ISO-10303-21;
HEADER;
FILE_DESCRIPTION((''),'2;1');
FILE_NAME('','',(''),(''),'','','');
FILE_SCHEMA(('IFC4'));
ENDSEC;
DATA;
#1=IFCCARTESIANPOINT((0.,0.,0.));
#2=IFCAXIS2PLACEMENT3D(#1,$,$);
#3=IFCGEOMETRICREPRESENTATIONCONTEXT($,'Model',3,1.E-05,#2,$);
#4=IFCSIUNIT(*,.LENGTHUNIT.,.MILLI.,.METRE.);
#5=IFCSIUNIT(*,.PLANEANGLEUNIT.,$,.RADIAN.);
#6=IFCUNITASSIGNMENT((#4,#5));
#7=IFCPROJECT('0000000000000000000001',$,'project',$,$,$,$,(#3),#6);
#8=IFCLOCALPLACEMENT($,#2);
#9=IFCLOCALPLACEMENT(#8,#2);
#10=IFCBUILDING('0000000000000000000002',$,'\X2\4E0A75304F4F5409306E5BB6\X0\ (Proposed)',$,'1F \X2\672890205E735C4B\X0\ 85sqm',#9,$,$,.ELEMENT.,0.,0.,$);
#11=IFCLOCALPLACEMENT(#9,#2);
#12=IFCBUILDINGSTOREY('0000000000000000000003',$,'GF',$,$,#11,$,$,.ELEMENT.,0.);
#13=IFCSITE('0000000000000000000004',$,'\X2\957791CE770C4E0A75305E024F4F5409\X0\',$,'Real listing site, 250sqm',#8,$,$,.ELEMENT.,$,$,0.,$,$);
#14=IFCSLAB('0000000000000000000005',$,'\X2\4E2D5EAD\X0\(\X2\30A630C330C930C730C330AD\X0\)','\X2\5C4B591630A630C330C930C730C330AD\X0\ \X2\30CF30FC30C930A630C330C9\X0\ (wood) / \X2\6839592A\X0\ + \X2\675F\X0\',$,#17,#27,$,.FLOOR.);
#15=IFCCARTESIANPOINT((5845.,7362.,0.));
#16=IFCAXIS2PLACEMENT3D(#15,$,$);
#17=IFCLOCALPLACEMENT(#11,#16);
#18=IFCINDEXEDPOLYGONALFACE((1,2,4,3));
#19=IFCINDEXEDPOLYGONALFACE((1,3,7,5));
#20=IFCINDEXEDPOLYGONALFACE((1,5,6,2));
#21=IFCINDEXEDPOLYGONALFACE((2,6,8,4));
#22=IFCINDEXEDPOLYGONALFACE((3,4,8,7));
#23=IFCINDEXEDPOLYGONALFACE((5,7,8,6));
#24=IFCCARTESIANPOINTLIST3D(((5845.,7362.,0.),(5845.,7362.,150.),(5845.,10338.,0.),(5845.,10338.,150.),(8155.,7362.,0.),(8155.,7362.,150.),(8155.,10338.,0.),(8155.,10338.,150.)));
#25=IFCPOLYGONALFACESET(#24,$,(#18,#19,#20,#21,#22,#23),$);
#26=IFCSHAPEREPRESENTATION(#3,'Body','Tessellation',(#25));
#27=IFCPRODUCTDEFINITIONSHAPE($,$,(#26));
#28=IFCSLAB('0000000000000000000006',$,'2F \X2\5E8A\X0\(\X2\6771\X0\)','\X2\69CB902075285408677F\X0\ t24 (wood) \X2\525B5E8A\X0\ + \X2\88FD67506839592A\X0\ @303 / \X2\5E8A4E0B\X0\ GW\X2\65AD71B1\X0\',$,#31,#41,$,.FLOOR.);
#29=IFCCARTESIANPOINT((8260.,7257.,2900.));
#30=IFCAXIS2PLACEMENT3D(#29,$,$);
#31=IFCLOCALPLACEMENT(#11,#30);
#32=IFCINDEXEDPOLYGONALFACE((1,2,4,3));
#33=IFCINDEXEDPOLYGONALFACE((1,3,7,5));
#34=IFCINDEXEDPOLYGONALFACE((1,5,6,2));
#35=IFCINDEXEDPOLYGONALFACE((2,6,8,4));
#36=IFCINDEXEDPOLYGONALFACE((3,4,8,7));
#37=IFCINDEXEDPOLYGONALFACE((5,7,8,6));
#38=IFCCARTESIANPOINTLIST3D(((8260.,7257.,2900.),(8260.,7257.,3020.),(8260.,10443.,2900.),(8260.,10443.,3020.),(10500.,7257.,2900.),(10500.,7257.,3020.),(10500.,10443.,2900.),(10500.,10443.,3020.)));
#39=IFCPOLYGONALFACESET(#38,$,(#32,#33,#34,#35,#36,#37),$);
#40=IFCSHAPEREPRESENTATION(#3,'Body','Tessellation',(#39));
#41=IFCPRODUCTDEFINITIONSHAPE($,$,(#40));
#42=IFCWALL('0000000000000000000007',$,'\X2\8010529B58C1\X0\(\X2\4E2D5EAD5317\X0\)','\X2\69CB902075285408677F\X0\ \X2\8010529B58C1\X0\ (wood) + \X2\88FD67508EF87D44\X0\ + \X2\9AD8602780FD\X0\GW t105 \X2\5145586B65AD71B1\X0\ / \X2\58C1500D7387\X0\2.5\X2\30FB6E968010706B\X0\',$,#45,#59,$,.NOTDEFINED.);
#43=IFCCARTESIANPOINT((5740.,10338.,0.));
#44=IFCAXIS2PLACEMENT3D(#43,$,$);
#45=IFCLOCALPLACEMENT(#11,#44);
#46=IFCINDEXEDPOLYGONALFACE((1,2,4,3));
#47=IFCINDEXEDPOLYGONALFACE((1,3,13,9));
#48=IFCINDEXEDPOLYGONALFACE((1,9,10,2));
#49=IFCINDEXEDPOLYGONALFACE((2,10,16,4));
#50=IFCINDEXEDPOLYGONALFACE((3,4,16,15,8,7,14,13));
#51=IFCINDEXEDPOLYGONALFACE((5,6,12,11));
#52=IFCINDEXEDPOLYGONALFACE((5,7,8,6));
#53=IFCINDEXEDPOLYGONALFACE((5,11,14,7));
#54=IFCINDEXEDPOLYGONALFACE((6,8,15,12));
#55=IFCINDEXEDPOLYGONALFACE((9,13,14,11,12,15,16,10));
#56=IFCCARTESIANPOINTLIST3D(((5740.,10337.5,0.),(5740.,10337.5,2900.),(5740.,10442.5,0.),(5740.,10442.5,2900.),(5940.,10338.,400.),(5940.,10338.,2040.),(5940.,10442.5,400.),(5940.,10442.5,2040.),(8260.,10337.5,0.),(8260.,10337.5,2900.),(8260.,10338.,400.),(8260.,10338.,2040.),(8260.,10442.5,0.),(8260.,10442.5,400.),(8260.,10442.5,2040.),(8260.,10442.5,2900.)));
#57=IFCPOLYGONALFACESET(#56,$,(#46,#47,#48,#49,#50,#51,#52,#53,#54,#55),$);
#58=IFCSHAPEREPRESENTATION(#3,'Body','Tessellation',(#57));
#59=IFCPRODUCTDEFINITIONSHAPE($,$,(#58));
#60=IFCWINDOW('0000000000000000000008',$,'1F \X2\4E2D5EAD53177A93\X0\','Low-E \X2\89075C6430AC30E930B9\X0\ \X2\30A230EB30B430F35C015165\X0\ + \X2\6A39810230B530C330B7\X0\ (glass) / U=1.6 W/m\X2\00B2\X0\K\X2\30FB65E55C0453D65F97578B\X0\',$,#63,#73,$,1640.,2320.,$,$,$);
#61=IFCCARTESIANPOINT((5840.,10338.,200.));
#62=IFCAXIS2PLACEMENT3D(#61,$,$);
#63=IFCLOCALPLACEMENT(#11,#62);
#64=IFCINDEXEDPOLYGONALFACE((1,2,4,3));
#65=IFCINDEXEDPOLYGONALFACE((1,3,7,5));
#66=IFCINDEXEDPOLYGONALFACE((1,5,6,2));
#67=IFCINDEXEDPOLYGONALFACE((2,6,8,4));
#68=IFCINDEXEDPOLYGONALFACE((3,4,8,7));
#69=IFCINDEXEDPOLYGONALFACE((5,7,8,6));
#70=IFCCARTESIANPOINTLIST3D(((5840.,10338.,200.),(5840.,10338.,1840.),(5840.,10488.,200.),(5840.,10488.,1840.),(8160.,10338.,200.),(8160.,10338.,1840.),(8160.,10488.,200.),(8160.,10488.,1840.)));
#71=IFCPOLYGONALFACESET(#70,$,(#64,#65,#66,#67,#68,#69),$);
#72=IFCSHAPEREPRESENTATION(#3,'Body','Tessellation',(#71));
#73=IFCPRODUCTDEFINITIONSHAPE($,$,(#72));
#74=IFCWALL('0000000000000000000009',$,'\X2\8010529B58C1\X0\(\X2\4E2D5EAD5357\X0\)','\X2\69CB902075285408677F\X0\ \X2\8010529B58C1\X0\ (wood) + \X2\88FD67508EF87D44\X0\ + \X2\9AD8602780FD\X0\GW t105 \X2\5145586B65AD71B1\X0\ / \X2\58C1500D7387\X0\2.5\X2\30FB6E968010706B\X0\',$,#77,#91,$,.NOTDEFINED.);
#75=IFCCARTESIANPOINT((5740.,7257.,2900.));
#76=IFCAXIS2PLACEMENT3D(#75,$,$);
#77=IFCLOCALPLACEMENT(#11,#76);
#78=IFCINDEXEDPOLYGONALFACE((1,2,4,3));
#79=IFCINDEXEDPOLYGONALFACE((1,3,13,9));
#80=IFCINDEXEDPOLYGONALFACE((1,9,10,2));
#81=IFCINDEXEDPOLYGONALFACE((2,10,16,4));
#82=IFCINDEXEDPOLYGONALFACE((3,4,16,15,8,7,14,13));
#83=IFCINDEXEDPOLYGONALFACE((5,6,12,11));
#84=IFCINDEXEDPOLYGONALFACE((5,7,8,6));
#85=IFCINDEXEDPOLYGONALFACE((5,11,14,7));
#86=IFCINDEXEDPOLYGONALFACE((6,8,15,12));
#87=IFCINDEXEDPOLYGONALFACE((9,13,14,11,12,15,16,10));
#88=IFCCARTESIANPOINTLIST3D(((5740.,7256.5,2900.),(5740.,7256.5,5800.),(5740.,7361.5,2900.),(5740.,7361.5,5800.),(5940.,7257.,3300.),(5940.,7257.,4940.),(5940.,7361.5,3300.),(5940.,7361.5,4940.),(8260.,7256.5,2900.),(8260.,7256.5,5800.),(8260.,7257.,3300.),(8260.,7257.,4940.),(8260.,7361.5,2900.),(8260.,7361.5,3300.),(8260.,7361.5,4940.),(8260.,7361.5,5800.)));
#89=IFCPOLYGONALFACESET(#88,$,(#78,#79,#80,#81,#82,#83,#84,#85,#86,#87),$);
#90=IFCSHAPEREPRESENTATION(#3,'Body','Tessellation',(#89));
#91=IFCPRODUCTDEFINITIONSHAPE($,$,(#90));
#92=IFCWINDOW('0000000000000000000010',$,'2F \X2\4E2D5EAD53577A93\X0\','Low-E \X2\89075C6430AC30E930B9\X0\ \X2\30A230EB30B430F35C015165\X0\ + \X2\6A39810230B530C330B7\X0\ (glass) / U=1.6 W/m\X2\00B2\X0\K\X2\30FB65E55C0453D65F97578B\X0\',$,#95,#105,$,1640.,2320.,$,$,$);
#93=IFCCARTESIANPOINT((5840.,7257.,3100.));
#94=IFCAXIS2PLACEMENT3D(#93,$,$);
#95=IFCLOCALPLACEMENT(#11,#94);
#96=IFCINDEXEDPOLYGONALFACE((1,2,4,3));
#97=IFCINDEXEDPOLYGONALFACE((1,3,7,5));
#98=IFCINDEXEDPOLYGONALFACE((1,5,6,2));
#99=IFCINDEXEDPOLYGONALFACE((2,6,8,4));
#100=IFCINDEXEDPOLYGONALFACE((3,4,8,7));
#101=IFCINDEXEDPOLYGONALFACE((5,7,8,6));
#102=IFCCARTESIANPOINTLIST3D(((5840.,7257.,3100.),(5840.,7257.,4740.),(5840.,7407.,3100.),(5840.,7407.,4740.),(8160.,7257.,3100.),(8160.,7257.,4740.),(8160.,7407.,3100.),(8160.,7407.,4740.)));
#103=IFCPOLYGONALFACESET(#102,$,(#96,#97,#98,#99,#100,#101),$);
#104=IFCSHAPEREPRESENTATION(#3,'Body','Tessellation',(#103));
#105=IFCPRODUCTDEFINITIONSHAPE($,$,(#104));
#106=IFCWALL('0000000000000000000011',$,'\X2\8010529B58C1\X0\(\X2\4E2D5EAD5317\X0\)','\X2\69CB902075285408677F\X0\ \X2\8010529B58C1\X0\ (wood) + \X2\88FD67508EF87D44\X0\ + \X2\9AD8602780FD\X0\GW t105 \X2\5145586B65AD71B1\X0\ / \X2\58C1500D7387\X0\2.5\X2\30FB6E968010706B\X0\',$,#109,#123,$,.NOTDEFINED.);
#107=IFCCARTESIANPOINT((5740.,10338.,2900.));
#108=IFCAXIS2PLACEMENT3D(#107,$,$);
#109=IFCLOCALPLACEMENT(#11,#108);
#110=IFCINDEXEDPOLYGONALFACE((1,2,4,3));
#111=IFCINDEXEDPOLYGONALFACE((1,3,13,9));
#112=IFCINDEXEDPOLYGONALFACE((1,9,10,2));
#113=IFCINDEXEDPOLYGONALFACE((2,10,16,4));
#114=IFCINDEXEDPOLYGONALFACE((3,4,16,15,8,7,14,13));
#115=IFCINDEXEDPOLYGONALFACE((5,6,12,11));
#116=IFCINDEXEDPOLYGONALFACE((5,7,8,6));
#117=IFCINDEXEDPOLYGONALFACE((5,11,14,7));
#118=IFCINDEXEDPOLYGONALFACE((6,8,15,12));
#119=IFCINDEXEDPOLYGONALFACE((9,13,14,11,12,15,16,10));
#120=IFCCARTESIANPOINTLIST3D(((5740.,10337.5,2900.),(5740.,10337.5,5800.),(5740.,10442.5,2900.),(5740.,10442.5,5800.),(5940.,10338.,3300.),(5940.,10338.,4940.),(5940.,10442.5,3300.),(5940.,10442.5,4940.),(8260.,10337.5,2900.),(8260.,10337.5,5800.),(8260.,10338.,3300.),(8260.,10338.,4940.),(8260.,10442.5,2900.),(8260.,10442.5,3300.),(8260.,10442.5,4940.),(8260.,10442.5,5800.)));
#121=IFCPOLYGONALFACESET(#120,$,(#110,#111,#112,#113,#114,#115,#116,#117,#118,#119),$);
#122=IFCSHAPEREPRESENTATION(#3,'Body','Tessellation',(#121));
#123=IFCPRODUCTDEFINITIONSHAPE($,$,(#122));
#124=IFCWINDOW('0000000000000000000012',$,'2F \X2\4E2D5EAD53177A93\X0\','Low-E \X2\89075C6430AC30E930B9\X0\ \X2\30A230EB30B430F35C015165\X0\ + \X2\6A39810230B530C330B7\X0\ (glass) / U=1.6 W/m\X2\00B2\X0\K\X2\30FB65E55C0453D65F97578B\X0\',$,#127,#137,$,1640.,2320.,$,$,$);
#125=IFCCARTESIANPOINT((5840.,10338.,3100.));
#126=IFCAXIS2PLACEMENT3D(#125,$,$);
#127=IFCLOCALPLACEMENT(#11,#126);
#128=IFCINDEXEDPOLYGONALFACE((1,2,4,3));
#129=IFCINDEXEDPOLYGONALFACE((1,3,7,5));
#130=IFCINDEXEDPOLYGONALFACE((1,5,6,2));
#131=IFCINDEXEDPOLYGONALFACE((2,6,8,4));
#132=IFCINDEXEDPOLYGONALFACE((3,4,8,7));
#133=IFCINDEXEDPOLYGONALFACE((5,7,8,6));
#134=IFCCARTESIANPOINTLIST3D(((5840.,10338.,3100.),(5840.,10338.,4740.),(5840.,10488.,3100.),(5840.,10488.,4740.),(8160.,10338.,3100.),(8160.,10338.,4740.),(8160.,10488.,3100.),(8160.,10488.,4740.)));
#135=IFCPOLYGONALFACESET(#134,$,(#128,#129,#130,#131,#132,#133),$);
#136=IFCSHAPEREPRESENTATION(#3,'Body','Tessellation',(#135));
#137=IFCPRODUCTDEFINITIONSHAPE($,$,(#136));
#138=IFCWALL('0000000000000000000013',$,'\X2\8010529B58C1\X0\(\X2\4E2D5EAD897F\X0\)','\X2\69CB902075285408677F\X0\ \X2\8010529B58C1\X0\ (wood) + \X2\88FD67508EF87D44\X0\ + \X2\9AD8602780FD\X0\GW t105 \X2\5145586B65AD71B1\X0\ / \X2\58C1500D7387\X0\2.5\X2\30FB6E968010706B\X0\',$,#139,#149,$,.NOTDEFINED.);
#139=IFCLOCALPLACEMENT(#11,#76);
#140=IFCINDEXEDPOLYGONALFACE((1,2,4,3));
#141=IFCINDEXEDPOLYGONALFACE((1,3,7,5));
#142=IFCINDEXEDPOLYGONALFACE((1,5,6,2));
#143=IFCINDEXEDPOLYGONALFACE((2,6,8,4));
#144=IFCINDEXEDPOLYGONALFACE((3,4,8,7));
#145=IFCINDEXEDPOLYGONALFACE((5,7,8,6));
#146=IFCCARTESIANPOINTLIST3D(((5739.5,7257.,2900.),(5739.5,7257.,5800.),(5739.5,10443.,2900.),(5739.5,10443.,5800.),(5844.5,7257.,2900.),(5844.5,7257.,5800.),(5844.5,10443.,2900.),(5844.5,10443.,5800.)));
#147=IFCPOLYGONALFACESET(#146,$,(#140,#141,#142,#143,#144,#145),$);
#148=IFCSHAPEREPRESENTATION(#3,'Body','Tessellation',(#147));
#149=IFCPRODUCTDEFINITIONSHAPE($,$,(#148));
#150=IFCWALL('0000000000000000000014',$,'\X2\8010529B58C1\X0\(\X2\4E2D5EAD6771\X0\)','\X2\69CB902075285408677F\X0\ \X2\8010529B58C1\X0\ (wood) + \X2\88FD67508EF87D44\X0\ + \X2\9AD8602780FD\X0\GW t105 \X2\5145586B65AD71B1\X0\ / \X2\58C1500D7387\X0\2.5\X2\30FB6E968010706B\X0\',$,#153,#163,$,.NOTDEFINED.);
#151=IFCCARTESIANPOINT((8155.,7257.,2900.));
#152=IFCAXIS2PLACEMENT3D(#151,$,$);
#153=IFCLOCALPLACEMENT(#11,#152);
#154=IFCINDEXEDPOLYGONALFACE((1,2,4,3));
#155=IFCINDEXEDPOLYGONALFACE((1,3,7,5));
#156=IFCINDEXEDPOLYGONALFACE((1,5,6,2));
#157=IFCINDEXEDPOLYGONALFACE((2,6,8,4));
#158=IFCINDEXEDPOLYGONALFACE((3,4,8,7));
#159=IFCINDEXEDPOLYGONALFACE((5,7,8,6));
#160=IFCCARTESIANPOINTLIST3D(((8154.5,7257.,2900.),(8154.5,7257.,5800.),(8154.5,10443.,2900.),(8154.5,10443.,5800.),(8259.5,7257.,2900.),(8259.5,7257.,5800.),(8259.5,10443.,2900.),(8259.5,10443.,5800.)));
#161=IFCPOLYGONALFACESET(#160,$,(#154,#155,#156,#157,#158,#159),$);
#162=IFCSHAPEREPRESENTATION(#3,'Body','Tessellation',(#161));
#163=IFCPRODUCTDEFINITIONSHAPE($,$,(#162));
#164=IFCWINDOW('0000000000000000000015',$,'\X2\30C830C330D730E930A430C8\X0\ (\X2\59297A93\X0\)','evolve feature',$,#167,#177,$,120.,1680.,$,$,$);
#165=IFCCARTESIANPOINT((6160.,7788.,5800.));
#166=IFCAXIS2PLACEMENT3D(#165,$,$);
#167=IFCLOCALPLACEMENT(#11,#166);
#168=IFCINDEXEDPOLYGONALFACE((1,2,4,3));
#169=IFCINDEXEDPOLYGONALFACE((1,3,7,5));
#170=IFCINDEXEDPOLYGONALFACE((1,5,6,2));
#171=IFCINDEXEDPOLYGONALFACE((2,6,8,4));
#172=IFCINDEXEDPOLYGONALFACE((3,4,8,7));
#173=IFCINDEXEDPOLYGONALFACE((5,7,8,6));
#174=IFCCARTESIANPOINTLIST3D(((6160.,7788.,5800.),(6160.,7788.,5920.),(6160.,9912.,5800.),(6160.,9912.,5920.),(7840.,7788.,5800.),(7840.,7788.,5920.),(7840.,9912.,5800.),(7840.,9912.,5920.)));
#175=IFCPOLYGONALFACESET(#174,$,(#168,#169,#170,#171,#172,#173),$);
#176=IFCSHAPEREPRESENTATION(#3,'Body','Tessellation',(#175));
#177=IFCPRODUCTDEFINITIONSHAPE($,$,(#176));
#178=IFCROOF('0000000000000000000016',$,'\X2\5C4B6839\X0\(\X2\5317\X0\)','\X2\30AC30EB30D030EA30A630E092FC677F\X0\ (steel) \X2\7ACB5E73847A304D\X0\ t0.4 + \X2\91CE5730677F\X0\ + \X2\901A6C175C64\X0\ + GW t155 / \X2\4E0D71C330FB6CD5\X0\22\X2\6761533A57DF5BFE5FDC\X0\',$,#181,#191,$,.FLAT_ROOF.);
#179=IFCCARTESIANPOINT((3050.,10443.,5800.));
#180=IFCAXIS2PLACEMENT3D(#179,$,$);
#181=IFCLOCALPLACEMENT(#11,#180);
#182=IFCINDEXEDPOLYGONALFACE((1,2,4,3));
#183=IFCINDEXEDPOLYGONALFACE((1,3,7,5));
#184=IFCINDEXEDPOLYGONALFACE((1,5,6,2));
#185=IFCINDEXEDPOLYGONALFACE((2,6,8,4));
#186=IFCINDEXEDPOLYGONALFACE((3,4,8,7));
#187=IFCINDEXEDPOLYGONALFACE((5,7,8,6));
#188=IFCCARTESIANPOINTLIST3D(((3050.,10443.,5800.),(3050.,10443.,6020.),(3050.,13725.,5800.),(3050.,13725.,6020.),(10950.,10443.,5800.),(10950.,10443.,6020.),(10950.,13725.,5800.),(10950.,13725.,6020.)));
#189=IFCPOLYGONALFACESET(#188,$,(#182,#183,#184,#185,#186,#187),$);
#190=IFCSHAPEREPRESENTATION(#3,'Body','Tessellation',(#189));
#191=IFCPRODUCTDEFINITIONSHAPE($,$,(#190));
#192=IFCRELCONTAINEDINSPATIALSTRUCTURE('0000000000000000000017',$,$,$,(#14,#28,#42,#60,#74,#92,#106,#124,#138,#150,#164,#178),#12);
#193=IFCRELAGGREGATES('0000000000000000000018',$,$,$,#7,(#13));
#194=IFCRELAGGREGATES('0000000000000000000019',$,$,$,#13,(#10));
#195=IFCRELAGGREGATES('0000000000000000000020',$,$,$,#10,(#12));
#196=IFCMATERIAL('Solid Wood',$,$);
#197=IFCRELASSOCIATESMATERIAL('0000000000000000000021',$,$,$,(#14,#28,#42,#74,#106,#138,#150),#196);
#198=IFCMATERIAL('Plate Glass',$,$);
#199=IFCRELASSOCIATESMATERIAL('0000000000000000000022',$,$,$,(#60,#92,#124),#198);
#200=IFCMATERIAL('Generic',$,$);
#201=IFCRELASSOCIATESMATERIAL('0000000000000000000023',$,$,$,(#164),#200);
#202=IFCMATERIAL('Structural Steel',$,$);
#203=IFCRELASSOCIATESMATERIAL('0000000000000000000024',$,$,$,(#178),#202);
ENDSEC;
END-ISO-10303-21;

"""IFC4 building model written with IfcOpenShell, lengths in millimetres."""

from ifc_helpers import new_model, si_unit, frame, frame_2d, origin, place, context, project, spatial, rectangle, extrude, material, element, fill, save


model = new_model("IFC4")

# Units and contexts
model_context = context("Model", 3, precision=1e-05, world=origin())
ifc_project = project(units=[si_unit("LENGTHUNIT", "METRE", prefix="MILLI"), si_unit("PLANEANGLEUNIT", "RADIAN")], contexts=[model_context])

# Site, building, storey
site_placement = place(None, origin())
site = spatial("IfcSite", under=ifc_project, at=site_placement, Name="長野県上田市住吉", ObjectType="Real listing site, 250sqm", CompositionType="ELEMENT", RefElevation=0.0)
building_placement = place(site_placement, origin())
building = spatial("IfcBuilding", under=site, at=building_placement, Name="上田住吉の家 (Proposed)", ObjectType="1F 木造平屋 85sqm", CompositionType="ELEMENT", ElevationOfRefHeight=0.0, ElevationOfTerrain=0.0)
storey_placement = place(building_placement, origin())
storey = spatial("IfcBuildingStorey", under=building, at=storey_placement, Name="GF", CompositionType="ELEMENT", Elevation=0.0)

# Slabs
ifc_material_1 = material(Name="Solid Wood")
slab_1_placement = place(storey_placement, frame((5845.0, 7362.0, 0.0)))
element("IfcSlab", 1, at=slab_1_placement, inside=storey, material=ifc_material_1, Name="中庭(ウッドデッキ)", Description="屋外ウッドデッキ ハードウッド (wood) / 根太 + 束", PredefinedType="FLOOR", context=model_context, shape_type="SweptSolid", body=[
    extrude(rectangle(XDim=2310.0, YDim=2976.0, at=frame_2d((1155.0, 1488.0))), frame((5845.0, 7362.0, 0.0)), (0.0, 0.0, 1.0), 150.0),
])
slab_2_placement = place(storey_placement, frame((8260.0, 7257.0, 2900.0)))
element("IfcSlab", 2, at=slab_2_placement, inside=storey, material=ifc_material_1, Name="2F 床(東)", Description="構造用合板 t24 (wood) 剛床 + 製材根太 @303 / 床下 GW断熱", PredefinedType="FLOOR", context=model_context, shape_type="SweptSolid", body=[
    extrude(rectangle(XDim=2240.0, YDim=3186.0, at=frame_2d((1120.0, 1593.0))), frame((8260.0, 7257.0, 2900.0)), (0.0, 0.0, 1.0), 120.0),
])

# Walls, openings, windows
wall_1_placement = place(storey_placement, frame((5740.0, 10338.0, 0.0)))
wall_1 = element("IfcWall", 3, at=wall_1_placement, inside=storey, material=ifc_material_1, Name="耐力壁(中庭北)", Description="構造用合板 耐力壁 (wood) + 製材軸組 + 高性能GW t105 充填断熱 / 壁倍率2.5・準耐火", PredefinedType="NOTDEFINED", context=model_context, shape_type="SweptSolid", body=[
    extrude(rectangle(XDim=2520.0, YDim=105.0, at=frame_2d((1260.0, 52.0))), frame((5740.0, 10338.0, 0.0)), (0.0, 0.0, 1.0), 2900.0),
])
opening_1_placement = place(storey_placement, frame((5840.0, 10338.0, 200.0)))
opening_1 = element("IfcOpeningElement", 4, at=opening_1_placement, cuts=wall_1, PredefinedType="NOTDEFINED", context=model_context, shape_type="SweptSolid", body=[
    extrude(rectangle(XDim=2320.0, YDim=150.0, at=frame_2d((1160.0, 75.0))), frame((5840.0, 10338.0, 200.0)), (0.0, 0.0, 1.0), 1640.0),
])
ifc_material_2 = material(Name="Plate Glass")
window_1_placement = place(storey_placement, frame((5840.0, 10338.0, 200.0)))
window_1 = element("IfcWindow", 5, at=window_1_placement, inside=storey, material=ifc_material_2, Name="1F 中庭北窓", Description="Low-E 複層ガラス アルゴン封入 + 樹脂サッシ (glass) / U=1.6 W/m²K・日射取得型", OverallHeight=1640.0, OverallWidth=2320.0, context=model_context, shape_type="SweptSolid", body=[
    extrude(rectangle(XDim=2320.0, YDim=150.0, at=frame_2d((1160.0, 75.0))), frame((5840.0, 10338.0, 200.0)), (0.0, 0.0, 1.0), 1640.0),
])
fill(opening_1, window_1)
wall_2_placement = place(storey_placement, frame((5740.0, 7257.0, 2900.0)))
wall_2 = element("IfcWall", 6, at=wall_2_placement, inside=storey, material=ifc_material_1, Name="耐力壁(中庭南)", Description="構造用合板 耐力壁 (wood) + 製材軸組 + 高性能GW t105 充填断熱 / 壁倍率2.5・準耐火", PredefinedType="NOTDEFINED", context=model_context, shape_type="SweptSolid", body=[
    extrude(rectangle(XDim=2520.0, YDim=105.0, at=frame_2d((1260.0, 52.0))), frame((5740.0, 7257.0, 2900.0)), (0.0, 0.0, 1.0), 2900.0),
])
opening_2_placement = place(storey_placement, frame((5840.0, 7257.0, 3100.0)))
opening_2 = element("IfcOpeningElement", 7, at=opening_2_placement, cuts=wall_2, PredefinedType="NOTDEFINED", context=model_context, shape_type="SweptSolid", body=[
    extrude(rectangle(XDim=2320.0, YDim=150.0, at=frame_2d((1160.0, 75.0))), frame((5840.0, 7257.0, 3100.0)), (0.0, 0.0, 1.0), 1640.0),
])
window_2_placement = place(storey_placement, frame((5840.0, 7257.0, 3100.0)))
window_2 = element("IfcWindow", 8, at=window_2_placement, inside=storey, material=ifc_material_2, Name="2F 中庭南窓", Description="Low-E 複層ガラス アルゴン封入 + 樹脂サッシ (glass) / U=1.6 W/m²K・日射取得型", OverallHeight=1640.0, OverallWidth=2320.0, context=model_context, shape_type="SweptSolid", body=[
    extrude(rectangle(XDim=2320.0, YDim=150.0, at=frame_2d((1160.0, 75.0))), frame((5840.0, 7257.0, 3100.0)), (0.0, 0.0, 1.0), 1640.0),
])
fill(opening_2, window_2)
wall_3_placement = place(storey_placement, frame((5740.0, 10338.0, 2900.0)))
wall_3 = element("IfcWall", 9, at=wall_3_placement, inside=storey, material=ifc_material_1, Name="耐力壁(中庭北)", Description="構造用合板 耐力壁 (wood) + 製材軸組 + 高性能GW t105 充填断熱 / 壁倍率2.5・準耐火", PredefinedType="NOTDEFINED", context=model_context, shape_type="SweptSolid", body=[
    extrude(rectangle(XDim=2520.0, YDim=105.0, at=frame_2d((1260.0, 52.0))), frame((5740.0, 10338.0, 2900.0)), (0.0, 0.0, 1.0), 2900.0),
])
opening_3_placement = place(storey_placement, frame((5840.0, 10338.0, 3100.0)))
opening_3 = element("IfcOpeningElement", 10, at=opening_3_placement, cuts=wall_3, PredefinedType="NOTDEFINED", context=model_context, shape_type="SweptSolid", body=[
    extrude(rectangle(XDim=2320.0, YDim=150.0, at=frame_2d((1160.0, 75.0))), frame((5840.0, 10338.0, 3100.0)), (0.0, 0.0, 1.0), 1640.0),
])
window_3_placement = place(storey_placement, frame((5840.0, 10338.0, 3100.0)))
window_3 = element("IfcWindow", 11, at=window_3_placement, inside=storey, material=ifc_material_2, Name="2F 中庭北窓", Description="Low-E 複層ガラス アルゴン封入 + 樹脂サッシ (glass) / U=1.6 W/m²K・日射取得型", OverallHeight=1640.0, OverallWidth=2320.0, context=model_context, shape_type="SweptSolid", body=[
    extrude(rectangle(XDim=2320.0, YDim=150.0, at=frame_2d((1160.0, 75.0))), frame((5840.0, 10338.0, 3100.0)), (0.0, 0.0, 1.0), 1640.0),
])
fill(opening_3, window_3)

# Walls
wall_4_placement = place(storey_placement, frame((5740.0, 7257.0, 2900.0)))
element("IfcWall", 12, at=wall_4_placement, inside=storey, material=ifc_material_1, Name="耐力壁(中庭西)", Description="構造用合板 耐力壁 (wood) + 製材軸組 + 高性能GW t105 充填断熱 / 壁倍率2.5・準耐火", PredefinedType="NOTDEFINED", context=model_context, shape_type="SweptSolid", body=[
    extrude(rectangle(XDim=105.0, YDim=3186.0, at=frame_2d((52.0, 1593.0))), frame((5740.0, 7257.0, 2900.0)), (0.0, 0.0, 1.0), 2900.0),
])
wall_5_placement = place(storey_placement, frame((8155.0, 7257.0, 2900.0)))
element("IfcWall", 13, at=wall_5_placement, inside=storey, material=ifc_material_1, Name="耐力壁(中庭東)", Description="構造用合板 耐力壁 (wood) + 製材軸組 + 高性能GW t105 充填断熱 / 壁倍率2.5・準耐火", PredefinedType="NOTDEFINED", context=model_context, shape_type="SweptSolid", body=[
    extrude(rectangle(XDim=105.0, YDim=3186.0, at=frame_2d((52.0, 1593.0))), frame((8155.0, 7257.0, 2900.0)), (0.0, 0.0, 1.0), 2900.0),
])

# Window
ifc_material_3 = material(Name="Generic")
window_4_placement = place(storey_placement, frame((6160.0, 7788.0, 5800.0)))
element("IfcWindow", 14, at=window_4_placement, inside=storey, material=ifc_material_3, Name="トップライト (天窓)", Description="evolve feature", OverallHeight=120.0, OverallWidth=1680.0, context=model_context, shape_type="SweptSolid", body=[
    extrude(rectangle(XDim=1680.0, YDim=2124.0, at=frame_2d((840.0, 1062.0))), frame((6160.0, 7788.0, 5800.0)), (0.0, 0.0, 1.0), 120.0),
])

# Roof
ifc_material_4 = material(Name="Structural Steel")
roof_1_placement = place(storey_placement, frame((3050.0, 10443.0, 5800.0)))
element("IfcRoof", 15, at=roof_1_placement, inside=storey, material=ifc_material_4, Name="屋根(北)", Description="ガルバリウム鋼板 (steel) 立平葺き t0.4 + 野地板 + 通気層 + GW t155 / 不燃・法22条区域対応", PredefinedType="FLAT_ROOF", context=model_context, shape_type="SweptSolid", body=[
    extrude(rectangle(XDim=7900.0, YDim=3282.0, at=frame_2d((3950.0, 1641.0))), frame((3050.0, 10443.0, 5800.0)), (0.0, 0.0, 1.0), 220.0),
])

save(model, "model.ifc")
